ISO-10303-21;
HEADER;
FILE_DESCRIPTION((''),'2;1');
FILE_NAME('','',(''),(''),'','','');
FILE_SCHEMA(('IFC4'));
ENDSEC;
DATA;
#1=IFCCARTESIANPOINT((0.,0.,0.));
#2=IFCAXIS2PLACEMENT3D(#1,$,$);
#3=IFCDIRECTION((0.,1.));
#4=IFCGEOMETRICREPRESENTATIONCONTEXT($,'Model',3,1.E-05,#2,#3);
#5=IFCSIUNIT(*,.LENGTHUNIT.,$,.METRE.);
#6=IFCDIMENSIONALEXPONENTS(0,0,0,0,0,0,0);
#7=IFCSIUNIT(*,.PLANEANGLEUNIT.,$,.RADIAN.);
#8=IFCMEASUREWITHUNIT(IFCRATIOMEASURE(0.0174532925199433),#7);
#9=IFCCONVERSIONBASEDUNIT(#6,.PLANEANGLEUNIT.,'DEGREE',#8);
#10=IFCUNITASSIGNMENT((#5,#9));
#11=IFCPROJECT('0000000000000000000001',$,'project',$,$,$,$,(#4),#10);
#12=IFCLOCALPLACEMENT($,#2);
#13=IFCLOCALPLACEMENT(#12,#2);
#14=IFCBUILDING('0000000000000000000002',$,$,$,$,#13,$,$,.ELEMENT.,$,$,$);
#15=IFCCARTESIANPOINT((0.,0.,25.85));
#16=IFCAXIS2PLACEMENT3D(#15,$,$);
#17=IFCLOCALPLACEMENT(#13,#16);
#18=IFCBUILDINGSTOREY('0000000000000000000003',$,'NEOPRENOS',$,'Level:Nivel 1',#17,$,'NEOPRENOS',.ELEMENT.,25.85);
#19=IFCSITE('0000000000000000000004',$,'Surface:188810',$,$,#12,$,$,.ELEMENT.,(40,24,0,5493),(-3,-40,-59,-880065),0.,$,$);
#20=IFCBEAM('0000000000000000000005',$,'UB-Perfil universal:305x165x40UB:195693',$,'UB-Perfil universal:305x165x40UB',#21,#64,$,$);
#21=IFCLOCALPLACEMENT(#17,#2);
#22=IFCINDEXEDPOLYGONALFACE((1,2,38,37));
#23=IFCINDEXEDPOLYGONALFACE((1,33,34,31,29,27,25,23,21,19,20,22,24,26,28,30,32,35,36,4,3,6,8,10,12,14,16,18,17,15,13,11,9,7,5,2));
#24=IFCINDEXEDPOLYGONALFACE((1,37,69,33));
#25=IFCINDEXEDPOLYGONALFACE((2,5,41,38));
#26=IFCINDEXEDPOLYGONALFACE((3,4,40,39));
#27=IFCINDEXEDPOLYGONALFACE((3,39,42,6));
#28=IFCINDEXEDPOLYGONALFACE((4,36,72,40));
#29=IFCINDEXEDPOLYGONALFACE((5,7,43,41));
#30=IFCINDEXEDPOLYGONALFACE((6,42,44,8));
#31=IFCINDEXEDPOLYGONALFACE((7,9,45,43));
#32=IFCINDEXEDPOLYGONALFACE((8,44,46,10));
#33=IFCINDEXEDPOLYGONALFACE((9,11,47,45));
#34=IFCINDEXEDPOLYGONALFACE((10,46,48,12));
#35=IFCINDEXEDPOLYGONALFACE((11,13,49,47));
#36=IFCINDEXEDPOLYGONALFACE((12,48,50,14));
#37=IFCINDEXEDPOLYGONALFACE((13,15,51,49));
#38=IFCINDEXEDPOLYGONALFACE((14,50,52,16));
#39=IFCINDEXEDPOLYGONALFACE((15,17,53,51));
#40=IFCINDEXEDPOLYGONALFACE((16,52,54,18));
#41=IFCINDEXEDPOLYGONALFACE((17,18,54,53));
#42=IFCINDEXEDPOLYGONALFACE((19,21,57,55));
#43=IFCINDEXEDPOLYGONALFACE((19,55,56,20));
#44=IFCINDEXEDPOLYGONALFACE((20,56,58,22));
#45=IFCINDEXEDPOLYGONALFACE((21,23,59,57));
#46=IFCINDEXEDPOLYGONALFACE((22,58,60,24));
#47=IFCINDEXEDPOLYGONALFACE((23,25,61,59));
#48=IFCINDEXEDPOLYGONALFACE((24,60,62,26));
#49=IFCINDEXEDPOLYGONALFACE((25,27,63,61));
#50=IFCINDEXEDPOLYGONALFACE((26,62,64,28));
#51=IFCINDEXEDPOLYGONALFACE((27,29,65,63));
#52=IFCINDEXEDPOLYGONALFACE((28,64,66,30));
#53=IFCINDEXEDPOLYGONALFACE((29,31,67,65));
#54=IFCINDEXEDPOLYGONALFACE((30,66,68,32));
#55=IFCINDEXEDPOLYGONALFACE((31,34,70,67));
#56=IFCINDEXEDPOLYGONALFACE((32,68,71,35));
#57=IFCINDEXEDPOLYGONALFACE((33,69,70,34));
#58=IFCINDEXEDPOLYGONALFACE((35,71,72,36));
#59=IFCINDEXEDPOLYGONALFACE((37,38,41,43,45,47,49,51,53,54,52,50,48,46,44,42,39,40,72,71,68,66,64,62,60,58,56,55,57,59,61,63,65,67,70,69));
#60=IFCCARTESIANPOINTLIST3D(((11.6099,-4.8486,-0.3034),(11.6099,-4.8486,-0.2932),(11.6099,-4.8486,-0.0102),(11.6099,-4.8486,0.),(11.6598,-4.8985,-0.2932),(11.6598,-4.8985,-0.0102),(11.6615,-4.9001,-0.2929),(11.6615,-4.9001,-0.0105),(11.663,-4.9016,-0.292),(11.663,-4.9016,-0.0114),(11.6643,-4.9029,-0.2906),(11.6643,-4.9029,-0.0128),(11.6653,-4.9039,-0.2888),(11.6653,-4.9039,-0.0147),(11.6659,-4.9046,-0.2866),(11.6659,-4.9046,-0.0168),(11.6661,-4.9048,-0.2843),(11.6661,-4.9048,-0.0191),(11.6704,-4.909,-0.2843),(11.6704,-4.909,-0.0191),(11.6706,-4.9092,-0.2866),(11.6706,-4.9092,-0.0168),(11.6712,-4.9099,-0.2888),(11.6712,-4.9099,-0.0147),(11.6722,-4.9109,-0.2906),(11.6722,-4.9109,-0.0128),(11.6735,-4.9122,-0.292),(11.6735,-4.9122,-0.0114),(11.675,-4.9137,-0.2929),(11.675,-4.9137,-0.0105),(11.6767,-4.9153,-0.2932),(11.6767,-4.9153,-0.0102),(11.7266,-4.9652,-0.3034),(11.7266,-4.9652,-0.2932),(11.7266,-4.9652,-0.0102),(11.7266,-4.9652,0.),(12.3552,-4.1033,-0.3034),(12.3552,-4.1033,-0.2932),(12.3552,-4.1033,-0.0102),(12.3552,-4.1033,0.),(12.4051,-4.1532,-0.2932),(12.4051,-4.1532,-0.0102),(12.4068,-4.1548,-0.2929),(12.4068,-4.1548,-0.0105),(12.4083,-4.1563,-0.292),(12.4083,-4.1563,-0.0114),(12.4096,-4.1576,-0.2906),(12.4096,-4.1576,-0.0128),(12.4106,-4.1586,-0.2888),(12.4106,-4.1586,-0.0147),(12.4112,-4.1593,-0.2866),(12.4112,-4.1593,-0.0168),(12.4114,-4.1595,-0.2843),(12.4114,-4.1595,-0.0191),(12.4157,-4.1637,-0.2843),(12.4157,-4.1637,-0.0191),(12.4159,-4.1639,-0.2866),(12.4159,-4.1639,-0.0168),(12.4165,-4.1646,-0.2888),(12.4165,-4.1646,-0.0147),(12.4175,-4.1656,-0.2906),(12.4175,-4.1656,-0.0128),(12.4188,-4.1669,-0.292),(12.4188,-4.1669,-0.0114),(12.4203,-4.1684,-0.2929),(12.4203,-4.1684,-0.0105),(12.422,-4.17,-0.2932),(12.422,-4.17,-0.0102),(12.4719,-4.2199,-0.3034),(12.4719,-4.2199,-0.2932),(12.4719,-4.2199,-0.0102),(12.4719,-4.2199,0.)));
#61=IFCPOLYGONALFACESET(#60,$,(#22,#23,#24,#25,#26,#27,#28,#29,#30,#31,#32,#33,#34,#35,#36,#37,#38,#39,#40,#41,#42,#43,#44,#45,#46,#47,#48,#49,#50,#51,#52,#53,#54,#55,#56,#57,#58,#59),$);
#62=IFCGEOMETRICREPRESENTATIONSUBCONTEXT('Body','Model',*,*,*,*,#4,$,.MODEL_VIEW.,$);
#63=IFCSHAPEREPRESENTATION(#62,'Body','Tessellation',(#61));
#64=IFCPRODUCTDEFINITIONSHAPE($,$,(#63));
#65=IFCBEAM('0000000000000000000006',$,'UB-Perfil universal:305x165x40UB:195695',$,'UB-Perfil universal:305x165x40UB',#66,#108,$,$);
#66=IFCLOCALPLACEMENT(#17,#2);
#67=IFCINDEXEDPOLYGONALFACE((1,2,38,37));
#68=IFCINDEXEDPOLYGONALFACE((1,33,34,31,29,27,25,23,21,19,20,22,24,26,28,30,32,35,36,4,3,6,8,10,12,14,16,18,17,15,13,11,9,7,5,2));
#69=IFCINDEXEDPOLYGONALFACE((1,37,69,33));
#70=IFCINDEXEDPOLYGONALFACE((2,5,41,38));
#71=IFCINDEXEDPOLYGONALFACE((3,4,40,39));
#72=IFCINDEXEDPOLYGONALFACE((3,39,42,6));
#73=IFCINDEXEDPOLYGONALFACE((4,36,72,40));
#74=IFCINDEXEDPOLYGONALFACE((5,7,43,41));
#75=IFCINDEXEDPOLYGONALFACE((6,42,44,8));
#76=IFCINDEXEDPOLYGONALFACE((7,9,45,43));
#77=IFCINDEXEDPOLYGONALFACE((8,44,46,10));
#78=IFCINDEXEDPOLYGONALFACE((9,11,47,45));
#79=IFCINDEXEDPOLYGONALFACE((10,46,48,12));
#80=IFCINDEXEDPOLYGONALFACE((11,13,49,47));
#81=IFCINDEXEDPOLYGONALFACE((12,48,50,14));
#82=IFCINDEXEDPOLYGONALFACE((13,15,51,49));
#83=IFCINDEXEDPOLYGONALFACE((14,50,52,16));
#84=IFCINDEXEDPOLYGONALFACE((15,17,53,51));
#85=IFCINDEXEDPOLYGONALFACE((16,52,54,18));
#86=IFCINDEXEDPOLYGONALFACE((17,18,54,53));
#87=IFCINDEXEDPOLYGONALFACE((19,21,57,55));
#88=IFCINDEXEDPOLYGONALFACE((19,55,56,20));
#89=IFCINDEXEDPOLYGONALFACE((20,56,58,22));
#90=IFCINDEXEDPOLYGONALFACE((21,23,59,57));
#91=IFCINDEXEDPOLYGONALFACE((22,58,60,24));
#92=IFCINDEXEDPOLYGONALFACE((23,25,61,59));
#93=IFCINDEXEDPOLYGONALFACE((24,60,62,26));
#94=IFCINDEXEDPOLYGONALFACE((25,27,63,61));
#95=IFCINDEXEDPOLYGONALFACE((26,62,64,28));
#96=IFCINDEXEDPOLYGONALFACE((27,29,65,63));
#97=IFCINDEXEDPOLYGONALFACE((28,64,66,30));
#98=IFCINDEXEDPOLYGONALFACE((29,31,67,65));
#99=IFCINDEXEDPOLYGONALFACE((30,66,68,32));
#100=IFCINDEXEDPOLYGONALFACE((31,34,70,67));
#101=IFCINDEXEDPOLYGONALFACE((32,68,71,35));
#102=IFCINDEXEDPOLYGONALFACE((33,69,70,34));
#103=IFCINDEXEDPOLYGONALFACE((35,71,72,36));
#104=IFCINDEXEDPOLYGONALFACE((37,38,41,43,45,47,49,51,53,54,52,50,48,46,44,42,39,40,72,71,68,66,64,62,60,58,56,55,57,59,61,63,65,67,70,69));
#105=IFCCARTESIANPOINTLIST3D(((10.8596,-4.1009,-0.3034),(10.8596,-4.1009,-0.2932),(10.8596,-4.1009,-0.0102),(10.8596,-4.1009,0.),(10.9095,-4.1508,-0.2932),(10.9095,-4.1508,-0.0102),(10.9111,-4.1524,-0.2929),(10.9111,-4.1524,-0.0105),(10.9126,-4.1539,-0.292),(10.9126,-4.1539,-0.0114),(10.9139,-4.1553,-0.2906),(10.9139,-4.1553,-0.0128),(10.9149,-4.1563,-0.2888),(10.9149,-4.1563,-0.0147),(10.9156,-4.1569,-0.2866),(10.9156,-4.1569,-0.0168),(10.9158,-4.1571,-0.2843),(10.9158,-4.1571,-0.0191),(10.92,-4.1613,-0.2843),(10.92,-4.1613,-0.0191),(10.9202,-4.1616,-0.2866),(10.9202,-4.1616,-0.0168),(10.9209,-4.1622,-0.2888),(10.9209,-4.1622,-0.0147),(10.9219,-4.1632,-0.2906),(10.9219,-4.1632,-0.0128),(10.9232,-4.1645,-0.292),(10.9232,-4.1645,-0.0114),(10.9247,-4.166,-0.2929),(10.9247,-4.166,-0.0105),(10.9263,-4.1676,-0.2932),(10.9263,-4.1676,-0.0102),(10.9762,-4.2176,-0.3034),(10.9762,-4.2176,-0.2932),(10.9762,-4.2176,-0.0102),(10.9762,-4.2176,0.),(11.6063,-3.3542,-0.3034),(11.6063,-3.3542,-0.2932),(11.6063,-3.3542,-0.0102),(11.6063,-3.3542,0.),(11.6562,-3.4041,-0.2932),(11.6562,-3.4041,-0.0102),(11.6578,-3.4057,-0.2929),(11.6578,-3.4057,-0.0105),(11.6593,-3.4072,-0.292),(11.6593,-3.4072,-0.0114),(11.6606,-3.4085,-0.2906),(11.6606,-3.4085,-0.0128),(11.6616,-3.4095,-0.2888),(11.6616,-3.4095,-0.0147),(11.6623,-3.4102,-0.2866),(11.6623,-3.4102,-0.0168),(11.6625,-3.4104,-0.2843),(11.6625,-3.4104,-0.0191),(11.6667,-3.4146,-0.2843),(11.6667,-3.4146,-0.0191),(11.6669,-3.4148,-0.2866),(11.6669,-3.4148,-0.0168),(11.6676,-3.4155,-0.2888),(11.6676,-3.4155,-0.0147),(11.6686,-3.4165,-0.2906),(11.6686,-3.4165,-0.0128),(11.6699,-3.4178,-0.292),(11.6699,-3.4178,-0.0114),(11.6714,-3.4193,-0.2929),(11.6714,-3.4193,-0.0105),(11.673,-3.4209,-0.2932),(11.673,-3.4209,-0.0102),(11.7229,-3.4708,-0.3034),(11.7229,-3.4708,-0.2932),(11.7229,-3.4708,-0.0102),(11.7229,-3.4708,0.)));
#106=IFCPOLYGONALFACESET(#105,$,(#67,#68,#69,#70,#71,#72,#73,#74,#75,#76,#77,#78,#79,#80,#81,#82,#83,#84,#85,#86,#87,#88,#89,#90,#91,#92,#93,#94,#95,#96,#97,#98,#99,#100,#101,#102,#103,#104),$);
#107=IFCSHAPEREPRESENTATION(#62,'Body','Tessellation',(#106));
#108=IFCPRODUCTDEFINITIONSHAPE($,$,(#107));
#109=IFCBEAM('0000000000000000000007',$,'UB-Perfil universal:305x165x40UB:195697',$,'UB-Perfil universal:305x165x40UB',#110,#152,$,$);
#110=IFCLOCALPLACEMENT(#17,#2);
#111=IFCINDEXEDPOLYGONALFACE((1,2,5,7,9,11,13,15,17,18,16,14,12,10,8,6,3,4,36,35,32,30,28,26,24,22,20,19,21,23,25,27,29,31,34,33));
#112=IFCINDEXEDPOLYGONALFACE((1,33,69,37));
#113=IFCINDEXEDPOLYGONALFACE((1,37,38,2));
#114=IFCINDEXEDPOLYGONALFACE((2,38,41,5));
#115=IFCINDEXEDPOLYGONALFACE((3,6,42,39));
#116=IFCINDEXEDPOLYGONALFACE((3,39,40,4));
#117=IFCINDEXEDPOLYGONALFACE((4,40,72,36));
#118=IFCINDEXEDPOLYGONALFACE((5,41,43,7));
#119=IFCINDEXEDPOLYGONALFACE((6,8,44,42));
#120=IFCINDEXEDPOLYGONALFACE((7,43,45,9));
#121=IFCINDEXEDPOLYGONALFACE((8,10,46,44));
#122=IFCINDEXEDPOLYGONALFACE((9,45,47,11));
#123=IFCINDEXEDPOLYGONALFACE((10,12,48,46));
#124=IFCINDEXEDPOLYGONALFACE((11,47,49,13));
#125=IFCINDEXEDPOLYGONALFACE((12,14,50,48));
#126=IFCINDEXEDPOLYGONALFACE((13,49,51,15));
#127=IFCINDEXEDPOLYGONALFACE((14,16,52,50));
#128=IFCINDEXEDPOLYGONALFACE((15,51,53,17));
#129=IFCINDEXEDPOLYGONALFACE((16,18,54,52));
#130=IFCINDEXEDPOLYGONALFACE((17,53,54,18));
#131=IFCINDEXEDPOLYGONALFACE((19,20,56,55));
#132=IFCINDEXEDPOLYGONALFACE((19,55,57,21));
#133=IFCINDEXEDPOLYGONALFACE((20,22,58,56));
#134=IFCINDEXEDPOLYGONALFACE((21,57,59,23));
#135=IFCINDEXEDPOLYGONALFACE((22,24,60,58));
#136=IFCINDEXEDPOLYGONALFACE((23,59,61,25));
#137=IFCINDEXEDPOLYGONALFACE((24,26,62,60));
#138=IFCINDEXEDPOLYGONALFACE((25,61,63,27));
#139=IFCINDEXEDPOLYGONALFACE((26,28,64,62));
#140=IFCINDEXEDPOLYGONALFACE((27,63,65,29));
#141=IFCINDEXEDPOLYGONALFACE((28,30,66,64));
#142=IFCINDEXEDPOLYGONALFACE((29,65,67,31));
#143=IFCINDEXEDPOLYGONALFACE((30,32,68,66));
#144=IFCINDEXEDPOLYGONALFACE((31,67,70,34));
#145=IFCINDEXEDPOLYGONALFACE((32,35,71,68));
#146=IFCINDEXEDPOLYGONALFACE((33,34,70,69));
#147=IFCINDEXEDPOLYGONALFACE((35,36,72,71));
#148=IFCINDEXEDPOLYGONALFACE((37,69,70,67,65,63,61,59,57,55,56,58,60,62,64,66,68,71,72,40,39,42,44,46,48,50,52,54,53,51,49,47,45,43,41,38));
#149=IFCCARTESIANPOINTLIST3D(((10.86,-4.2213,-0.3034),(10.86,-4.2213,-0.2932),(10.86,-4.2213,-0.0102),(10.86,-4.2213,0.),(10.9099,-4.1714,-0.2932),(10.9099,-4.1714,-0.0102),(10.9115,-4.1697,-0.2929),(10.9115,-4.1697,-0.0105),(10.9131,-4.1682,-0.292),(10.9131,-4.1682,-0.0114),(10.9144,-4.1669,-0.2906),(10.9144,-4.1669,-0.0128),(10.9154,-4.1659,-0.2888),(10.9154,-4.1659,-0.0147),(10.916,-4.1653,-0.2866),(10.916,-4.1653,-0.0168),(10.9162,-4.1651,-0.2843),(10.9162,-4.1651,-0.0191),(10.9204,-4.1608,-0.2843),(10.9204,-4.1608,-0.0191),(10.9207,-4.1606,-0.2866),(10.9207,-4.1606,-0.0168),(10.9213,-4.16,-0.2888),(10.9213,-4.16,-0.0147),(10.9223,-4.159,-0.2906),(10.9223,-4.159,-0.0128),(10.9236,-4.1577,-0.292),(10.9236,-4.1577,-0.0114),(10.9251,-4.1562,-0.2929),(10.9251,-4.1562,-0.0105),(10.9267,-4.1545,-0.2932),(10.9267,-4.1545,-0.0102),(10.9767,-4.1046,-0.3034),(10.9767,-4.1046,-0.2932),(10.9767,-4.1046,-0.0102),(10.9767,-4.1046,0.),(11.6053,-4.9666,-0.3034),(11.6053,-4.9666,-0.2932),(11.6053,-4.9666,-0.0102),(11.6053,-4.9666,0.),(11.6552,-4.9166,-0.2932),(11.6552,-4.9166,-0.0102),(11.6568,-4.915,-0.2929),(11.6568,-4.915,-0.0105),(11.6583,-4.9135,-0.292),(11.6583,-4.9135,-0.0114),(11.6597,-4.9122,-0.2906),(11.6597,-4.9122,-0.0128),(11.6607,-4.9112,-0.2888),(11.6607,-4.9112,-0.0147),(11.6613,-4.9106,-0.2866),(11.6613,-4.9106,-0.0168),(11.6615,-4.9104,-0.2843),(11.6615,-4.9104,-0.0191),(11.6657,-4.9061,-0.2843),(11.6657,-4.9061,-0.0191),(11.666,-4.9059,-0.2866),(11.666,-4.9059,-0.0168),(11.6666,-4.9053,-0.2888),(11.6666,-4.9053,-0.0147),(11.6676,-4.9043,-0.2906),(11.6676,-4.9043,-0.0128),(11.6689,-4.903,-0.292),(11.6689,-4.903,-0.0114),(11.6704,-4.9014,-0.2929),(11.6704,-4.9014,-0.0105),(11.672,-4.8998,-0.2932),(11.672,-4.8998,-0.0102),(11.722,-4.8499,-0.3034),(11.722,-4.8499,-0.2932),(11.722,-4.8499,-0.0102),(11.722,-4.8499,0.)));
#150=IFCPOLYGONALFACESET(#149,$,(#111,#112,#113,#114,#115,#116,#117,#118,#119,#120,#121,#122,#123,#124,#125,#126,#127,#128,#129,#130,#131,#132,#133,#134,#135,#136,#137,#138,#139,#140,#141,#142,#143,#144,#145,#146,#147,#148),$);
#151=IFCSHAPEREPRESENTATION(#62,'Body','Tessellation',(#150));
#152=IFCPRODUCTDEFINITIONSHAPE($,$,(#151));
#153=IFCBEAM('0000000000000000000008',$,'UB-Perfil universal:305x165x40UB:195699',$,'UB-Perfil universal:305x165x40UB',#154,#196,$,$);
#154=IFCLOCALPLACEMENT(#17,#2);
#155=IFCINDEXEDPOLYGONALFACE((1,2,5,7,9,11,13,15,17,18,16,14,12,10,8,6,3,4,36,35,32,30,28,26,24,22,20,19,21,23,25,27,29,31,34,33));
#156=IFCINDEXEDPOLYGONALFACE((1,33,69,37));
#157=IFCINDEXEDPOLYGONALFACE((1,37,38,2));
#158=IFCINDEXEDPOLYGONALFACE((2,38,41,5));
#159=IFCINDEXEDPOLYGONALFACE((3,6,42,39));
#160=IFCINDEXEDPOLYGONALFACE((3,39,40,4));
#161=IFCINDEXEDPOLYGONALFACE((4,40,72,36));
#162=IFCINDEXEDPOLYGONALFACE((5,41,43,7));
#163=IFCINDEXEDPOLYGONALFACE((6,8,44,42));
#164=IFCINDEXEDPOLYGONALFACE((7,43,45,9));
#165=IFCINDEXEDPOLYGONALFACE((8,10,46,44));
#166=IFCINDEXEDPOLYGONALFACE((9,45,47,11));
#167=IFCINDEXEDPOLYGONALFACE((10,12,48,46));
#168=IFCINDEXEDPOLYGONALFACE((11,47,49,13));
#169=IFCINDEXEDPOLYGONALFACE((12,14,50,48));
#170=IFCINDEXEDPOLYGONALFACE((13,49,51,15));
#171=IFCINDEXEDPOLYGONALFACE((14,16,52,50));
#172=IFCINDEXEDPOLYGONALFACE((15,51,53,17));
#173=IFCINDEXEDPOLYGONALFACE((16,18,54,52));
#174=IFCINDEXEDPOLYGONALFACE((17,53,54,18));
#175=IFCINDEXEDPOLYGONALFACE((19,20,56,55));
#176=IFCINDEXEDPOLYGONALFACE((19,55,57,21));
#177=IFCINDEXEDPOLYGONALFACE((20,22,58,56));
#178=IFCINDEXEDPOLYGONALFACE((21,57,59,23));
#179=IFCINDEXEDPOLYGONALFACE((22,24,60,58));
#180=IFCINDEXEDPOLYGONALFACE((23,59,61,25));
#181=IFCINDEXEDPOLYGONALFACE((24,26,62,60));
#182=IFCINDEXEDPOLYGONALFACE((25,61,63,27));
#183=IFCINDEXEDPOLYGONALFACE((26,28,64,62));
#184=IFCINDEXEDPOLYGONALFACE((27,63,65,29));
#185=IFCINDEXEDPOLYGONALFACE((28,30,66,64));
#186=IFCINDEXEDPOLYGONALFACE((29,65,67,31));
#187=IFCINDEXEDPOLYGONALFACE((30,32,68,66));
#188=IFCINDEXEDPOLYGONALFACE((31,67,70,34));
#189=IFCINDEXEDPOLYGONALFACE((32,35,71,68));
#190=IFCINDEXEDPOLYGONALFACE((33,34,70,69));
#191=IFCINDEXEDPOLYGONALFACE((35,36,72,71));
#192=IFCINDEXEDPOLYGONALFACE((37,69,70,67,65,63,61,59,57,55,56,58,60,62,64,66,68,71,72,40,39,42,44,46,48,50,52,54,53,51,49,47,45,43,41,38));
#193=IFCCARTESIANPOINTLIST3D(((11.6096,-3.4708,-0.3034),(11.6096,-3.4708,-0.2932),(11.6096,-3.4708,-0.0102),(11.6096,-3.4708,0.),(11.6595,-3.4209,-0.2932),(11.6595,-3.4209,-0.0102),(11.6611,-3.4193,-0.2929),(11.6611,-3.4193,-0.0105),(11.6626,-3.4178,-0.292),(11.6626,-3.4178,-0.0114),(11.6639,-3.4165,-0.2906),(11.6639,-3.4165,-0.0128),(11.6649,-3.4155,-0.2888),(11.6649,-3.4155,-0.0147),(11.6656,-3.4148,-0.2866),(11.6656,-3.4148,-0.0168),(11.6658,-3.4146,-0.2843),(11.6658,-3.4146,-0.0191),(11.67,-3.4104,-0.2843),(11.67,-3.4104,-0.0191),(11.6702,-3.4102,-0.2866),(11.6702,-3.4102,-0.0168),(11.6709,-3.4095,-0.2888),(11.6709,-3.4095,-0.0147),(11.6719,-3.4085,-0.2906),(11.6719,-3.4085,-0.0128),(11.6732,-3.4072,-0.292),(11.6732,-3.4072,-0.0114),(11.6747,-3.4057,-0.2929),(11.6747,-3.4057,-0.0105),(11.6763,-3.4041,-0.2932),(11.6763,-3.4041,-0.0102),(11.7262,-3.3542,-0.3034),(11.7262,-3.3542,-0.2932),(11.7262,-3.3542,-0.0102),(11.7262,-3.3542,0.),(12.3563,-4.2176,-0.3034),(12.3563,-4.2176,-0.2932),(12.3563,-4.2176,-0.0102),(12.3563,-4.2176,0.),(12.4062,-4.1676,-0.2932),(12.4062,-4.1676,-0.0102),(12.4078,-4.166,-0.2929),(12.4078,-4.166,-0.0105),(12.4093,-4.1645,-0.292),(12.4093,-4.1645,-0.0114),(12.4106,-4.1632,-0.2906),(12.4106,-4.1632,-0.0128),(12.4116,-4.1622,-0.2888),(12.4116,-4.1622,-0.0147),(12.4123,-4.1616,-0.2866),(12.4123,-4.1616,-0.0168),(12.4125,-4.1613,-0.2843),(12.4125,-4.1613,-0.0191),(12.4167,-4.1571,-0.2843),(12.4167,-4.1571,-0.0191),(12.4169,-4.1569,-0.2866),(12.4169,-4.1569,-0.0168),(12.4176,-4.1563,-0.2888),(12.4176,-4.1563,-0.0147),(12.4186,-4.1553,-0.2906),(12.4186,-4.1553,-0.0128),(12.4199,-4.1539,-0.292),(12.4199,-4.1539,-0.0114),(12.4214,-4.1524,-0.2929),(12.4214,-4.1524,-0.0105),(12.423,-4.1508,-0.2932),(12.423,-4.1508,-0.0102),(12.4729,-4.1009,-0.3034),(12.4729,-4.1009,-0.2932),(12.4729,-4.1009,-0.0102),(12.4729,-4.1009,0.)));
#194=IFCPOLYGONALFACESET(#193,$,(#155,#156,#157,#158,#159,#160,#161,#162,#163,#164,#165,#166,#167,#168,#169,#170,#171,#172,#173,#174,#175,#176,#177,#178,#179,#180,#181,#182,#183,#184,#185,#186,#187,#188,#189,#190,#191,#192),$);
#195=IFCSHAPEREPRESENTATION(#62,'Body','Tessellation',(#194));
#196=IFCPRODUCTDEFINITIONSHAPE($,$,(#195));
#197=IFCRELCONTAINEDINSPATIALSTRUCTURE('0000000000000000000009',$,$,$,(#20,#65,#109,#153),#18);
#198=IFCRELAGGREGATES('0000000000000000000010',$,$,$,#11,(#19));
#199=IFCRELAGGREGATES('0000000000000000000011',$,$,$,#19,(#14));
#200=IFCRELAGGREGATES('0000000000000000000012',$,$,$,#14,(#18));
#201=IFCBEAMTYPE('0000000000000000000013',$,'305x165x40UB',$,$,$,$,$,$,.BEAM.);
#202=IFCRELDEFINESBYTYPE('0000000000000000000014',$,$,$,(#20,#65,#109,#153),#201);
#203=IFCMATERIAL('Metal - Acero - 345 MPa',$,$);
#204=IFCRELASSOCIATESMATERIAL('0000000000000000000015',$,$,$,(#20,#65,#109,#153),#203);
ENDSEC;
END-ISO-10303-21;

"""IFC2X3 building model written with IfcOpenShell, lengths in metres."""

from ifc_helpers import new_model, entity, si_unit, converted_unit, direction, frame, frame_2d, origin, place, context, subcontext, project, spatial, i_section, extrude, material, type_object, element, save


model = new_model("IFC2X3")

# Units and contexts
model_context = context("Model", 3, precision=1e-05, world=origin(), true_north=direction((0.0, 1.0)))
body_context = subcontext(model_context, "Body", "Model", "MODEL_VIEW")
ifc_project = project(units=[si_unit("LENGTHUNIT", "METRE"), converted_unit("PLANEANGLEUNIT", "DEGREE", entity("IfcRatioMeasure", 0.0174532925199433), si_unit("PLANEANGLEUNIT", "RADIAN"), dimensions=[0, 0, 0, 0, 0, 0, 0])], contexts=[model_context])

# Site, building, storey
site_placement = place(None, origin())
site = spatial("IfcSite", under=ifc_project, at=site_placement, Name="Surface:188810", CompositionType="ELEMENT", RefLatitude=(40, 24, 0, 5493), RefLongitude=(-3, -40, -59, -880065), RefElevation=0.0)
building_placement = place(site_placement, origin())
building = spatial("IfcBuilding", under=site, at=building_placement, CompositionType="ELEMENT")
storey_placement = place(building_placement, frame((0.0, 0.0, 25.85)))
storey = spatial("IfcBuildingStorey", under=building, at=storey_placement, Name="NEOPRENOS", ObjectType="Level:Nivel 1", LongName="NEOPRENOS", CompositionType="ELEMENT", Elevation=25.85)

# Beams
ifc_material_1 = material(Name="Metal - Acero - 345 MPa")
beam_type = type_object("IfcBeamType", Name="305x165x40UB", PredefinedType="BEAM")
beam_1_placement = place(storey_placement, frame((11.6663, -4.9089, 0.0), z_axis=(0.0, 0.0, 1.0), x_axis=(0.707107, 0.707107, 0.0)))
element("IfcBeam", 1, at=beam_1_placement, inside=storey, type_object=beam_type, material=ifc_material_1, Name="UB-Perfil universal:305x165x40UB:195693", ObjectType="UB-Perfil universal:305x165x40UB", context=body_context, shape_type="SweptSolid", body=[
    extrude(i_section(OverallWidth=0.165, OverallDepth=0.3034, WebThickness=0.006, FlangeThickness=0.0102, FilletRadius=0.0089, at=frame_2d((0.0, 0.0), x_axis=(0.0, 1.0))), frame((0.0028, 0.0, -0.1517), z_axis=(1.0, 0.0, 0.0), x_axis=(0.0, 0.0, -1.0)), (0.0, 0.0, 1.0), 1.054),
])
beam_2_placement = place(storey_placement, frame((11.6663, -3.4109, 0.0), z_axis=(0.0, 0.0, 1.0), x_axis=(-0.707107, -0.707107, 0.0)))
element("IfcBeam", 2, at=beam_2_placement, inside=storey, type_object=beam_type, material=ifc_material_1, Name="UB-Perfil universal:305x165x40UB:195695", ObjectType="UB-Perfil universal:305x165x40UB", context=body_context, shape_type="SweptSolid", body=[
    extrude(i_section(OverallWidth=0.165, OverallDepth=0.3034, WebThickness=0.006, FlangeThickness=0.0102, FilletRadius=0.0089, at=frame_2d((0.0, 0.0), x_axis=(0.0, 1.0))), frame((0.0023, 0.0, -0.1517), z_axis=(1.0, 0.0, 0.0), x_axis=(0.0, 0.0, -1.0)), (0.0, 0.0, 1.0), 1.056),
])
beam_3_placement = place(storey_placement, frame((10.9163, -4.1609, 0.0), z_axis=(0.0, 0.0, 1.0), x_axis=(0.707107, -0.707107, 0.0)))
element("IfcBeam", 3, at=beam_3_placement, inside=storey, type_object=beam_type, material=ifc_material_1, Name="UB-Perfil universal:305x165x40UB:195697", ObjectType="UB-Perfil universal:305x165x40UB", context=body_context, shape_type="SweptSolid", body=[
    extrude(i_section(OverallWidth=0.165, OverallDepth=0.3034, WebThickness=0.006, FlangeThickness=0.0102, FilletRadius=0.0089, at=frame_2d((0.0, 0.0), x_axis=(0.0, 1.0))), frame((0.0029, 0.0, -0.1517), z_axis=(1.0, 0.0, 0.0), x_axis=(0.0, 0.0, -1.0)), (0.0, 0.0, 1.0), 1.054),
])
beam_4_placement = place(storey_placement, frame((12.4163, -4.1609, 0.0), z_axis=(0.0, 0.0, 1.0), x_axis=(-0.707107, 0.707107, 0.0)))
element("IfcBeam", 4, at=beam_4_placement, inside=storey, type_object=beam_type, material=ifc_material_1, Name="UB-Perfil universal:305x165x40UB:195699", ObjectType="UB-Perfil universal:305x165x40UB", context=body_context, shape_type="SweptSolid", body=[
    extrude(i_section(OverallWidth=0.165, OverallDepth=0.3034, WebThickness=0.006, FlangeThickness=0.0102, FilletRadius=0.0089, at=frame_2d((0.0, 0.0), x_axis=(0.0, 1.0))), frame((0.0023, 0.0, -0.1517), z_axis=(1.0, 0.0, 0.0), x_axis=(0.0, 0.0, -1.0)), (0.0, 0.0, 1.0), 1.056),
])

save(model, "model.ifc")
